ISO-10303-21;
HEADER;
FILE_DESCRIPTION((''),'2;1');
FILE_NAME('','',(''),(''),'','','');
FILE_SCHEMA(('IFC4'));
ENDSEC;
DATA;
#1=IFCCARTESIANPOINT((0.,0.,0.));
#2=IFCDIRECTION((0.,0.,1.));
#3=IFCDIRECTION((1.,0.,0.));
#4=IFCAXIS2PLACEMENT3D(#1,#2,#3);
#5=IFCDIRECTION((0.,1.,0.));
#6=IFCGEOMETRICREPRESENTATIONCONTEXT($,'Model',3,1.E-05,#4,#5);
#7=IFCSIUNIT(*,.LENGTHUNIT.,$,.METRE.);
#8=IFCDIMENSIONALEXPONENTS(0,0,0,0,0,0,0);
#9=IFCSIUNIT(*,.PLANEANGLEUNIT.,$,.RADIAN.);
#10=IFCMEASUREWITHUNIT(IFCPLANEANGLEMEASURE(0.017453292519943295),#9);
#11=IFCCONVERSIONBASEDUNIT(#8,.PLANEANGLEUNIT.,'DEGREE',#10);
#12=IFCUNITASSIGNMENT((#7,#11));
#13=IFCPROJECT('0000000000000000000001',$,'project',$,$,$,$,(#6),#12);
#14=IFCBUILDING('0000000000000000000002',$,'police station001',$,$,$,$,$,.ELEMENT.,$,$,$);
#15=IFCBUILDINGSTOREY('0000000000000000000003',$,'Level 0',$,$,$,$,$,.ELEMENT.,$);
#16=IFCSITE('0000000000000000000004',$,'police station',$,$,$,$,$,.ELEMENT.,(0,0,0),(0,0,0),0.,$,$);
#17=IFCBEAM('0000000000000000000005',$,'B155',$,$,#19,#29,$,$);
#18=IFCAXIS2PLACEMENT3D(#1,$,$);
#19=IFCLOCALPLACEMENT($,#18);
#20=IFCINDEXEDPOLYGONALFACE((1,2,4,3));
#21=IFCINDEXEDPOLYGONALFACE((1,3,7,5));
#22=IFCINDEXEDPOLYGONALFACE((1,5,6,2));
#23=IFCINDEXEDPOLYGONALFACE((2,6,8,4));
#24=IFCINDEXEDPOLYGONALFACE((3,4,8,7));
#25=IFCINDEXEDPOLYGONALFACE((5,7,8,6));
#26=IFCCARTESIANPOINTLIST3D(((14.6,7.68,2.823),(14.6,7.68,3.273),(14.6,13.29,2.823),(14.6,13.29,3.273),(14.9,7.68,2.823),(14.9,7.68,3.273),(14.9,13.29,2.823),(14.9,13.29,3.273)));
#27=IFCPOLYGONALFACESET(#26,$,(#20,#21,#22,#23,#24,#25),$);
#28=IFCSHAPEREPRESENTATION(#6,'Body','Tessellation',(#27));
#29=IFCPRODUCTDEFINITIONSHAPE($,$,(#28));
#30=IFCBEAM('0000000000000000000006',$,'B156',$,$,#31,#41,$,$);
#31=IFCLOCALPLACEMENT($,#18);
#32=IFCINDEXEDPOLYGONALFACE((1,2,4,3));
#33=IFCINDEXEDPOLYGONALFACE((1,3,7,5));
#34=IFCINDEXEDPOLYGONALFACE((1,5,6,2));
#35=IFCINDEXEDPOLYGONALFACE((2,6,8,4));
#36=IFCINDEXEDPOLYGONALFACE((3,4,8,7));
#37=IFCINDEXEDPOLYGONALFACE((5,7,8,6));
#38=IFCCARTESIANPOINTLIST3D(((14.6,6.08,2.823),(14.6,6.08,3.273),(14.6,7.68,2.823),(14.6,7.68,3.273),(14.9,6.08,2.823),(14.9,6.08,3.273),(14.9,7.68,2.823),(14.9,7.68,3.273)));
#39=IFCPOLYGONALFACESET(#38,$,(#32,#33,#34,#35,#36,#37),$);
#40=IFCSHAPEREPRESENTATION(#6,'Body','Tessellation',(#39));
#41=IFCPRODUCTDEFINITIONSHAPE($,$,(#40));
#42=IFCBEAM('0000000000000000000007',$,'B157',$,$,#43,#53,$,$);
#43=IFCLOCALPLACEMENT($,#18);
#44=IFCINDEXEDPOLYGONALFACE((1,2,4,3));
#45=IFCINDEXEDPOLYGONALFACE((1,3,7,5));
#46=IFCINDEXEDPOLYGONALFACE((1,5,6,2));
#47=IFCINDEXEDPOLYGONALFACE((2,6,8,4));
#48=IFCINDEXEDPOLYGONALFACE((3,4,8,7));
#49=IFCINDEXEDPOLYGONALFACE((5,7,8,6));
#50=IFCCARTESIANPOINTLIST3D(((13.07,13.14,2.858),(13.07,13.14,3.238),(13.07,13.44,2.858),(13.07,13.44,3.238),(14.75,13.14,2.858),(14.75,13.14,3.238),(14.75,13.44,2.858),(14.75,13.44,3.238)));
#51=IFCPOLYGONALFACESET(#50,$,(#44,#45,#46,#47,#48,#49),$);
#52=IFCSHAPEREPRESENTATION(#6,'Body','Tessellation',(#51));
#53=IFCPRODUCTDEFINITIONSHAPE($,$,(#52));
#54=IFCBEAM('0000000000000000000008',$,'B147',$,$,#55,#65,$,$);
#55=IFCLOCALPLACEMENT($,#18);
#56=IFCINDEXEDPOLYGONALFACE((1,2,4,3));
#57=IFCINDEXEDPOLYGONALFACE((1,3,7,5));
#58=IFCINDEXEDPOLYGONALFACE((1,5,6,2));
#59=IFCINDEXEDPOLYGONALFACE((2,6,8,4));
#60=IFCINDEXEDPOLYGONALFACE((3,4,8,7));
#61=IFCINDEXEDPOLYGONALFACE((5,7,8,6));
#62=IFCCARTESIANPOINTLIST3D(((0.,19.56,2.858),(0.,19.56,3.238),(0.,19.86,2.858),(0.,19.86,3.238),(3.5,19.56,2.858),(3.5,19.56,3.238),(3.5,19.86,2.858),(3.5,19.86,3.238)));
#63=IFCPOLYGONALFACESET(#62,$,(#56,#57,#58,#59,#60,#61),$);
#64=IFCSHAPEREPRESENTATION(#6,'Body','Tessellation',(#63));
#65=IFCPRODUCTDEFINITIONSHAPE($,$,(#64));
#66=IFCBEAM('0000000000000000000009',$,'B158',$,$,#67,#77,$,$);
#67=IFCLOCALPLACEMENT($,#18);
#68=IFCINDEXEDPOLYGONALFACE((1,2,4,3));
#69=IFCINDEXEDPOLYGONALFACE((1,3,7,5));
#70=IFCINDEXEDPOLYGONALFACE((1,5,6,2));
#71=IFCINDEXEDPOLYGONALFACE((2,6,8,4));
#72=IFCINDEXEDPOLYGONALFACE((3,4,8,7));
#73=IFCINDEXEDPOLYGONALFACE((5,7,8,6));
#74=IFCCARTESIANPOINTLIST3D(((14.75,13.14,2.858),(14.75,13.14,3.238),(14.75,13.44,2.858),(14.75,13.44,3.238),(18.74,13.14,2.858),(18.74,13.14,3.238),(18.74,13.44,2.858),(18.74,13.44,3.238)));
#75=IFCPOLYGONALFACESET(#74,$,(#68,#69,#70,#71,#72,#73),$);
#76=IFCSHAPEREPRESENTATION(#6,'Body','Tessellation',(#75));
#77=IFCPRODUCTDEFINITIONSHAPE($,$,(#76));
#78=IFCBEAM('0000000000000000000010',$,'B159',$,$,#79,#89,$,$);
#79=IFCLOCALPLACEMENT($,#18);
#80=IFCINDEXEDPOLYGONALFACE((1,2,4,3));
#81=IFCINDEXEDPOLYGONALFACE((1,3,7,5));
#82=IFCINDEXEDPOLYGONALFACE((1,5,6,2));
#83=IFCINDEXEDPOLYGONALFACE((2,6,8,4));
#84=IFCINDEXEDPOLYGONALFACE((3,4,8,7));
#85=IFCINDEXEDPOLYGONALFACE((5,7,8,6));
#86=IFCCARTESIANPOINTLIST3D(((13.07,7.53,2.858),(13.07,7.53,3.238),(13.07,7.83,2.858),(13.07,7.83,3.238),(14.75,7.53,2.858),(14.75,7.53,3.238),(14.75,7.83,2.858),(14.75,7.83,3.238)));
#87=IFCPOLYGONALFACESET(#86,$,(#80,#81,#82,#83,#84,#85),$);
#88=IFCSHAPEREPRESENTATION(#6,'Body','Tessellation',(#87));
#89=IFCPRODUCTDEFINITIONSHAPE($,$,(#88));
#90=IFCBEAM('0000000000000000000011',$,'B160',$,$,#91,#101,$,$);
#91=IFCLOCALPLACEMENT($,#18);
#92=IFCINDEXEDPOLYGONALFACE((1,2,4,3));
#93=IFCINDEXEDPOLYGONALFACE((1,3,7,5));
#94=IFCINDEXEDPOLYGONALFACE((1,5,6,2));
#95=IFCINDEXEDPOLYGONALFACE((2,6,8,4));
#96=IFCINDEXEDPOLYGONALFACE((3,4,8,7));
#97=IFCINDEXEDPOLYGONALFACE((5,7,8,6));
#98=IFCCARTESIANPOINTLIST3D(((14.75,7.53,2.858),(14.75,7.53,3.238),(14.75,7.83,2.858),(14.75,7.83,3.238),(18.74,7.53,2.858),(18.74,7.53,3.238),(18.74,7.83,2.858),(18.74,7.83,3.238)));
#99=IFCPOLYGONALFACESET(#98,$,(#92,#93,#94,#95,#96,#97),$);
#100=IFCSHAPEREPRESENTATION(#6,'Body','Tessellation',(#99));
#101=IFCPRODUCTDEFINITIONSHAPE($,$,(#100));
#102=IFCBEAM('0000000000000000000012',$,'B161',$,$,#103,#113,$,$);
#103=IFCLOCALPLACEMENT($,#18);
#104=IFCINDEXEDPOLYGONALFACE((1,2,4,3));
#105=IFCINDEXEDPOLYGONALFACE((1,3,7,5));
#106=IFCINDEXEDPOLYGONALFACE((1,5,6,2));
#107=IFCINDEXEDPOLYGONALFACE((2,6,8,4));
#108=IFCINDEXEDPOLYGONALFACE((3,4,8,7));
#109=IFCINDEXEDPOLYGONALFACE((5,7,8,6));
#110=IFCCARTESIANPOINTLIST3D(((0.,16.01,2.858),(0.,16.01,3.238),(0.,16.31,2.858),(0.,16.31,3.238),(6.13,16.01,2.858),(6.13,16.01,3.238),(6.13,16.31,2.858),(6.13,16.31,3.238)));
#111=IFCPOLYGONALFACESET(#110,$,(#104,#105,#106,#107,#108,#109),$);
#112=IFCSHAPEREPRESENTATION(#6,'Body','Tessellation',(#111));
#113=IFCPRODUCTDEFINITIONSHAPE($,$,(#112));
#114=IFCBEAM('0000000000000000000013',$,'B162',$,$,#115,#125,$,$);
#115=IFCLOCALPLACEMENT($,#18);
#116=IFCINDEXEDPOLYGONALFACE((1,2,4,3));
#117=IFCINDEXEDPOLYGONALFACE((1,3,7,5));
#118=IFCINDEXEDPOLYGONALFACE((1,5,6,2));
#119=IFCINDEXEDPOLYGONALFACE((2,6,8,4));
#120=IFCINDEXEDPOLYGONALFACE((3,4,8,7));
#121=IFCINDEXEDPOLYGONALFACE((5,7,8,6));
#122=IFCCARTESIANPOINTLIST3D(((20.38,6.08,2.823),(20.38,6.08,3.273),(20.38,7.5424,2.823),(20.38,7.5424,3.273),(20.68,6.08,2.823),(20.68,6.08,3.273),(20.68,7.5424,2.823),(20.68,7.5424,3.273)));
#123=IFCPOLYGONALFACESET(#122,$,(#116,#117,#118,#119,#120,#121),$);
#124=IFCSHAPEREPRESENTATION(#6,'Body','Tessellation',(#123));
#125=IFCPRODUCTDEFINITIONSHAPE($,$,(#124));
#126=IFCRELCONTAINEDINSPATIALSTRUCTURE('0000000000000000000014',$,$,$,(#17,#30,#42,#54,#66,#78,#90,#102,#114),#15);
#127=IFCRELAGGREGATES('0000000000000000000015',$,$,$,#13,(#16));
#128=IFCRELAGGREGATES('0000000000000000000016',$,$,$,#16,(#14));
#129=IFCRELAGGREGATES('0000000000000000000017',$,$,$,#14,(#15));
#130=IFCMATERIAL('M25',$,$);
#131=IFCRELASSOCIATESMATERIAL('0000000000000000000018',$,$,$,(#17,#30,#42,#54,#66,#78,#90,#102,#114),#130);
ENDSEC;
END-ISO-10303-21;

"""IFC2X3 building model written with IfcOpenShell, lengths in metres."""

from ifc_helpers import new_model, entity, si_unit, converted_unit, direction, frame, frame_2d, origin_with_axes, place, context, project, spatial, rectangle, extrude, material, element, save


model = new_model("IFC2X3")

# Units and contexts
model_context = context("Model", 3, precision=1e-05, world=origin_with_axes(), true_north=direction((0.0, 1.0, 0.0)))
ifc_project = project(units=[si_unit("LENGTHUNIT", "METRE"), converted_unit("PLANEANGLEUNIT", "DEGREE", entity("IfcPlaneAngleMeasure", 0.017453292519943295), si_unit("PLANEANGLEUNIT", "RADIAN"), dimensions=[0, 0, 0, 0, 0, 0, 0])], contexts=[model_context])

# Site, building, storey
site = spatial("IfcSite", under=ifc_project, Name="police station", CompositionType="ELEMENT", RefLatitude=(0, 0, 0), RefLongitude=(0, 0, 0), RefElevation=0.0)
building = spatial("IfcBuilding", under=site, Name="police station001", CompositionType="ELEMENT")
storey = spatial("IfcBuildingStorey", under=building, Name="Level 0", CompositionType="ELEMENT")

# Beams
ifc_material = material(Name="M25")
placement = place(None, origin_with_axes())
element("IfcBeam", 1, at=placement, inside=storey, material=ifc_material, Name="B155", context=model_context, shape_type="SweptSolid", body=[
    extrude(rectangle(XDim=0.3, YDim=0.45, at=frame_2d((0.0, 0.0), x_axis=(0.0, 1.0, 0.0))), frame((14.75, 7.68, 3.048), z_axis=(0.0, 1.0, 0.0), x_axis=(0.0, 0.0, -1.0)), (0.0, 0.0, 1.0), 5.61),
])
element("IfcBeam", 2, at=placement, inside=storey, material=ifc_material, Name="B156", context=model_context, shape_type="SweptSolid", body=[
    extrude(rectangle(XDim=0.3, YDim=0.45, at=frame_2d((0.0, 0.0), x_axis=(0.0, 1.0, 0.0))), frame((14.75, 6.08, 3.048), z_axis=(0.0, 1.0, 0.0), x_axis=(0.0, 0.0, -1.0)), (0.0, 0.0, 1.0), 1.6),
])
element("IfcBeam", 3, at=placement, inside=storey, material=ifc_material, Name="B157", context=model_context, shape_type="SweptSolid", body=[
    extrude(rectangle(XDim=0.3, YDim=0.38, at=frame_2d((0.0, 0.0), x_axis=(0.0, 1.0, 0.0))), frame((13.07, 13.29, 3.048), z_axis=(1.0, 0.0, 0.0), x_axis=(0.0, 0.0, -1.0)), (0.0, 0.0, 1.0), 1.68),
])
element("IfcBeam", 4, at=placement, inside=storey, material=ifc_material, Name="B147", context=model_context, shape_type="SweptSolid", body=[
    extrude(rectangle(XDim=0.3, YDim=0.38, at=frame_2d((0.0, 0.0), x_axis=(0.0, 1.0, 0.0))), frame((0.0, 19.71, 3.048), z_axis=(1.0, 0.0, 0.0), x_axis=(0.0, 0.0, -1.0)), (0.0, 0.0, 1.0), 3.5),
])
element("IfcBeam", 5, at=placement, inside=storey, material=ifc_material, Name="B158", context=model_context, shape_type="SweptSolid", body=[
    extrude(rectangle(XDim=0.3, YDim=0.38, at=frame_2d((0.0, 0.0), x_axis=(0.0, 1.0, 0.0))), frame((14.75, 13.29, 3.048), z_axis=(1.0, 0.0, 0.0), x_axis=(0.0, 0.0, -1.0)), (0.0, 0.0, 1.0), 3.99),
])
element("IfcBeam", 6, at=placement, inside=storey, material=ifc_material, Name="B159", context=model_context, shape_type="SweptSolid", body=[
    extrude(rectangle(XDim=0.3, YDim=0.38, at=frame_2d((0.0, 0.0), x_axis=(0.0, 1.0, 0.0))), frame((13.07, 7.68, 3.048), z_axis=(1.0, 0.0, 0.0), x_axis=(0.0, 0.0, -1.0)), (0.0, 0.0, 1.0), 1.68),
])
element("IfcBeam", 7, at=placement, inside=storey, material=ifc_material, Name="B160", context=model_context, shape_type="SweptSolid", body=[
    extrude(rectangle(XDim=0.3, YDim=0.38, at=frame_2d((0.0, 0.0), x_axis=(0.0, 1.0, 0.0))), frame((14.75, 7.68, 3.048), z_axis=(1.0, 0.0, 0.0), x_axis=(0.0, 0.0, -1.0)), (0.0, 0.0, 1.0), 3.99),
])
element("IfcBeam", 8, at=placement, inside=storey, material=ifc_material, Name="B161", context=model_context, shape_type="SweptSolid", body=[
    extrude(rectangle(XDim=0.3, YDim=0.38, at=frame_2d((0.0, 0.0), x_axis=(0.0, 1.0, 0.0))), frame((6.13, 16.16, 3.048), z_axis=(-1.0, 0.0, 0.0), x_axis=(0.0, 0.0, -1.0)), (0.0, 0.0, 1.0), 6.13),
])
element("IfcBeam", 9, at=placement, inside=storey, material=ifc_material, Name="B162", context=model_context, shape_type="SweptSolid", body=[
    extrude(rectangle(XDim=0.3, YDim=0.45, at=frame_2d((0.0, 0.0), x_axis=(0.0, 1.0, 0.0))), frame((20.53, 6.08, 3.048), z_axis=(0.0, 1.0, 0.0), x_axis=(0.0, 0.0, -1.0)), (0.0, 0.0, 1.0), 1.4624),
])

save(model, "model.ifc")
